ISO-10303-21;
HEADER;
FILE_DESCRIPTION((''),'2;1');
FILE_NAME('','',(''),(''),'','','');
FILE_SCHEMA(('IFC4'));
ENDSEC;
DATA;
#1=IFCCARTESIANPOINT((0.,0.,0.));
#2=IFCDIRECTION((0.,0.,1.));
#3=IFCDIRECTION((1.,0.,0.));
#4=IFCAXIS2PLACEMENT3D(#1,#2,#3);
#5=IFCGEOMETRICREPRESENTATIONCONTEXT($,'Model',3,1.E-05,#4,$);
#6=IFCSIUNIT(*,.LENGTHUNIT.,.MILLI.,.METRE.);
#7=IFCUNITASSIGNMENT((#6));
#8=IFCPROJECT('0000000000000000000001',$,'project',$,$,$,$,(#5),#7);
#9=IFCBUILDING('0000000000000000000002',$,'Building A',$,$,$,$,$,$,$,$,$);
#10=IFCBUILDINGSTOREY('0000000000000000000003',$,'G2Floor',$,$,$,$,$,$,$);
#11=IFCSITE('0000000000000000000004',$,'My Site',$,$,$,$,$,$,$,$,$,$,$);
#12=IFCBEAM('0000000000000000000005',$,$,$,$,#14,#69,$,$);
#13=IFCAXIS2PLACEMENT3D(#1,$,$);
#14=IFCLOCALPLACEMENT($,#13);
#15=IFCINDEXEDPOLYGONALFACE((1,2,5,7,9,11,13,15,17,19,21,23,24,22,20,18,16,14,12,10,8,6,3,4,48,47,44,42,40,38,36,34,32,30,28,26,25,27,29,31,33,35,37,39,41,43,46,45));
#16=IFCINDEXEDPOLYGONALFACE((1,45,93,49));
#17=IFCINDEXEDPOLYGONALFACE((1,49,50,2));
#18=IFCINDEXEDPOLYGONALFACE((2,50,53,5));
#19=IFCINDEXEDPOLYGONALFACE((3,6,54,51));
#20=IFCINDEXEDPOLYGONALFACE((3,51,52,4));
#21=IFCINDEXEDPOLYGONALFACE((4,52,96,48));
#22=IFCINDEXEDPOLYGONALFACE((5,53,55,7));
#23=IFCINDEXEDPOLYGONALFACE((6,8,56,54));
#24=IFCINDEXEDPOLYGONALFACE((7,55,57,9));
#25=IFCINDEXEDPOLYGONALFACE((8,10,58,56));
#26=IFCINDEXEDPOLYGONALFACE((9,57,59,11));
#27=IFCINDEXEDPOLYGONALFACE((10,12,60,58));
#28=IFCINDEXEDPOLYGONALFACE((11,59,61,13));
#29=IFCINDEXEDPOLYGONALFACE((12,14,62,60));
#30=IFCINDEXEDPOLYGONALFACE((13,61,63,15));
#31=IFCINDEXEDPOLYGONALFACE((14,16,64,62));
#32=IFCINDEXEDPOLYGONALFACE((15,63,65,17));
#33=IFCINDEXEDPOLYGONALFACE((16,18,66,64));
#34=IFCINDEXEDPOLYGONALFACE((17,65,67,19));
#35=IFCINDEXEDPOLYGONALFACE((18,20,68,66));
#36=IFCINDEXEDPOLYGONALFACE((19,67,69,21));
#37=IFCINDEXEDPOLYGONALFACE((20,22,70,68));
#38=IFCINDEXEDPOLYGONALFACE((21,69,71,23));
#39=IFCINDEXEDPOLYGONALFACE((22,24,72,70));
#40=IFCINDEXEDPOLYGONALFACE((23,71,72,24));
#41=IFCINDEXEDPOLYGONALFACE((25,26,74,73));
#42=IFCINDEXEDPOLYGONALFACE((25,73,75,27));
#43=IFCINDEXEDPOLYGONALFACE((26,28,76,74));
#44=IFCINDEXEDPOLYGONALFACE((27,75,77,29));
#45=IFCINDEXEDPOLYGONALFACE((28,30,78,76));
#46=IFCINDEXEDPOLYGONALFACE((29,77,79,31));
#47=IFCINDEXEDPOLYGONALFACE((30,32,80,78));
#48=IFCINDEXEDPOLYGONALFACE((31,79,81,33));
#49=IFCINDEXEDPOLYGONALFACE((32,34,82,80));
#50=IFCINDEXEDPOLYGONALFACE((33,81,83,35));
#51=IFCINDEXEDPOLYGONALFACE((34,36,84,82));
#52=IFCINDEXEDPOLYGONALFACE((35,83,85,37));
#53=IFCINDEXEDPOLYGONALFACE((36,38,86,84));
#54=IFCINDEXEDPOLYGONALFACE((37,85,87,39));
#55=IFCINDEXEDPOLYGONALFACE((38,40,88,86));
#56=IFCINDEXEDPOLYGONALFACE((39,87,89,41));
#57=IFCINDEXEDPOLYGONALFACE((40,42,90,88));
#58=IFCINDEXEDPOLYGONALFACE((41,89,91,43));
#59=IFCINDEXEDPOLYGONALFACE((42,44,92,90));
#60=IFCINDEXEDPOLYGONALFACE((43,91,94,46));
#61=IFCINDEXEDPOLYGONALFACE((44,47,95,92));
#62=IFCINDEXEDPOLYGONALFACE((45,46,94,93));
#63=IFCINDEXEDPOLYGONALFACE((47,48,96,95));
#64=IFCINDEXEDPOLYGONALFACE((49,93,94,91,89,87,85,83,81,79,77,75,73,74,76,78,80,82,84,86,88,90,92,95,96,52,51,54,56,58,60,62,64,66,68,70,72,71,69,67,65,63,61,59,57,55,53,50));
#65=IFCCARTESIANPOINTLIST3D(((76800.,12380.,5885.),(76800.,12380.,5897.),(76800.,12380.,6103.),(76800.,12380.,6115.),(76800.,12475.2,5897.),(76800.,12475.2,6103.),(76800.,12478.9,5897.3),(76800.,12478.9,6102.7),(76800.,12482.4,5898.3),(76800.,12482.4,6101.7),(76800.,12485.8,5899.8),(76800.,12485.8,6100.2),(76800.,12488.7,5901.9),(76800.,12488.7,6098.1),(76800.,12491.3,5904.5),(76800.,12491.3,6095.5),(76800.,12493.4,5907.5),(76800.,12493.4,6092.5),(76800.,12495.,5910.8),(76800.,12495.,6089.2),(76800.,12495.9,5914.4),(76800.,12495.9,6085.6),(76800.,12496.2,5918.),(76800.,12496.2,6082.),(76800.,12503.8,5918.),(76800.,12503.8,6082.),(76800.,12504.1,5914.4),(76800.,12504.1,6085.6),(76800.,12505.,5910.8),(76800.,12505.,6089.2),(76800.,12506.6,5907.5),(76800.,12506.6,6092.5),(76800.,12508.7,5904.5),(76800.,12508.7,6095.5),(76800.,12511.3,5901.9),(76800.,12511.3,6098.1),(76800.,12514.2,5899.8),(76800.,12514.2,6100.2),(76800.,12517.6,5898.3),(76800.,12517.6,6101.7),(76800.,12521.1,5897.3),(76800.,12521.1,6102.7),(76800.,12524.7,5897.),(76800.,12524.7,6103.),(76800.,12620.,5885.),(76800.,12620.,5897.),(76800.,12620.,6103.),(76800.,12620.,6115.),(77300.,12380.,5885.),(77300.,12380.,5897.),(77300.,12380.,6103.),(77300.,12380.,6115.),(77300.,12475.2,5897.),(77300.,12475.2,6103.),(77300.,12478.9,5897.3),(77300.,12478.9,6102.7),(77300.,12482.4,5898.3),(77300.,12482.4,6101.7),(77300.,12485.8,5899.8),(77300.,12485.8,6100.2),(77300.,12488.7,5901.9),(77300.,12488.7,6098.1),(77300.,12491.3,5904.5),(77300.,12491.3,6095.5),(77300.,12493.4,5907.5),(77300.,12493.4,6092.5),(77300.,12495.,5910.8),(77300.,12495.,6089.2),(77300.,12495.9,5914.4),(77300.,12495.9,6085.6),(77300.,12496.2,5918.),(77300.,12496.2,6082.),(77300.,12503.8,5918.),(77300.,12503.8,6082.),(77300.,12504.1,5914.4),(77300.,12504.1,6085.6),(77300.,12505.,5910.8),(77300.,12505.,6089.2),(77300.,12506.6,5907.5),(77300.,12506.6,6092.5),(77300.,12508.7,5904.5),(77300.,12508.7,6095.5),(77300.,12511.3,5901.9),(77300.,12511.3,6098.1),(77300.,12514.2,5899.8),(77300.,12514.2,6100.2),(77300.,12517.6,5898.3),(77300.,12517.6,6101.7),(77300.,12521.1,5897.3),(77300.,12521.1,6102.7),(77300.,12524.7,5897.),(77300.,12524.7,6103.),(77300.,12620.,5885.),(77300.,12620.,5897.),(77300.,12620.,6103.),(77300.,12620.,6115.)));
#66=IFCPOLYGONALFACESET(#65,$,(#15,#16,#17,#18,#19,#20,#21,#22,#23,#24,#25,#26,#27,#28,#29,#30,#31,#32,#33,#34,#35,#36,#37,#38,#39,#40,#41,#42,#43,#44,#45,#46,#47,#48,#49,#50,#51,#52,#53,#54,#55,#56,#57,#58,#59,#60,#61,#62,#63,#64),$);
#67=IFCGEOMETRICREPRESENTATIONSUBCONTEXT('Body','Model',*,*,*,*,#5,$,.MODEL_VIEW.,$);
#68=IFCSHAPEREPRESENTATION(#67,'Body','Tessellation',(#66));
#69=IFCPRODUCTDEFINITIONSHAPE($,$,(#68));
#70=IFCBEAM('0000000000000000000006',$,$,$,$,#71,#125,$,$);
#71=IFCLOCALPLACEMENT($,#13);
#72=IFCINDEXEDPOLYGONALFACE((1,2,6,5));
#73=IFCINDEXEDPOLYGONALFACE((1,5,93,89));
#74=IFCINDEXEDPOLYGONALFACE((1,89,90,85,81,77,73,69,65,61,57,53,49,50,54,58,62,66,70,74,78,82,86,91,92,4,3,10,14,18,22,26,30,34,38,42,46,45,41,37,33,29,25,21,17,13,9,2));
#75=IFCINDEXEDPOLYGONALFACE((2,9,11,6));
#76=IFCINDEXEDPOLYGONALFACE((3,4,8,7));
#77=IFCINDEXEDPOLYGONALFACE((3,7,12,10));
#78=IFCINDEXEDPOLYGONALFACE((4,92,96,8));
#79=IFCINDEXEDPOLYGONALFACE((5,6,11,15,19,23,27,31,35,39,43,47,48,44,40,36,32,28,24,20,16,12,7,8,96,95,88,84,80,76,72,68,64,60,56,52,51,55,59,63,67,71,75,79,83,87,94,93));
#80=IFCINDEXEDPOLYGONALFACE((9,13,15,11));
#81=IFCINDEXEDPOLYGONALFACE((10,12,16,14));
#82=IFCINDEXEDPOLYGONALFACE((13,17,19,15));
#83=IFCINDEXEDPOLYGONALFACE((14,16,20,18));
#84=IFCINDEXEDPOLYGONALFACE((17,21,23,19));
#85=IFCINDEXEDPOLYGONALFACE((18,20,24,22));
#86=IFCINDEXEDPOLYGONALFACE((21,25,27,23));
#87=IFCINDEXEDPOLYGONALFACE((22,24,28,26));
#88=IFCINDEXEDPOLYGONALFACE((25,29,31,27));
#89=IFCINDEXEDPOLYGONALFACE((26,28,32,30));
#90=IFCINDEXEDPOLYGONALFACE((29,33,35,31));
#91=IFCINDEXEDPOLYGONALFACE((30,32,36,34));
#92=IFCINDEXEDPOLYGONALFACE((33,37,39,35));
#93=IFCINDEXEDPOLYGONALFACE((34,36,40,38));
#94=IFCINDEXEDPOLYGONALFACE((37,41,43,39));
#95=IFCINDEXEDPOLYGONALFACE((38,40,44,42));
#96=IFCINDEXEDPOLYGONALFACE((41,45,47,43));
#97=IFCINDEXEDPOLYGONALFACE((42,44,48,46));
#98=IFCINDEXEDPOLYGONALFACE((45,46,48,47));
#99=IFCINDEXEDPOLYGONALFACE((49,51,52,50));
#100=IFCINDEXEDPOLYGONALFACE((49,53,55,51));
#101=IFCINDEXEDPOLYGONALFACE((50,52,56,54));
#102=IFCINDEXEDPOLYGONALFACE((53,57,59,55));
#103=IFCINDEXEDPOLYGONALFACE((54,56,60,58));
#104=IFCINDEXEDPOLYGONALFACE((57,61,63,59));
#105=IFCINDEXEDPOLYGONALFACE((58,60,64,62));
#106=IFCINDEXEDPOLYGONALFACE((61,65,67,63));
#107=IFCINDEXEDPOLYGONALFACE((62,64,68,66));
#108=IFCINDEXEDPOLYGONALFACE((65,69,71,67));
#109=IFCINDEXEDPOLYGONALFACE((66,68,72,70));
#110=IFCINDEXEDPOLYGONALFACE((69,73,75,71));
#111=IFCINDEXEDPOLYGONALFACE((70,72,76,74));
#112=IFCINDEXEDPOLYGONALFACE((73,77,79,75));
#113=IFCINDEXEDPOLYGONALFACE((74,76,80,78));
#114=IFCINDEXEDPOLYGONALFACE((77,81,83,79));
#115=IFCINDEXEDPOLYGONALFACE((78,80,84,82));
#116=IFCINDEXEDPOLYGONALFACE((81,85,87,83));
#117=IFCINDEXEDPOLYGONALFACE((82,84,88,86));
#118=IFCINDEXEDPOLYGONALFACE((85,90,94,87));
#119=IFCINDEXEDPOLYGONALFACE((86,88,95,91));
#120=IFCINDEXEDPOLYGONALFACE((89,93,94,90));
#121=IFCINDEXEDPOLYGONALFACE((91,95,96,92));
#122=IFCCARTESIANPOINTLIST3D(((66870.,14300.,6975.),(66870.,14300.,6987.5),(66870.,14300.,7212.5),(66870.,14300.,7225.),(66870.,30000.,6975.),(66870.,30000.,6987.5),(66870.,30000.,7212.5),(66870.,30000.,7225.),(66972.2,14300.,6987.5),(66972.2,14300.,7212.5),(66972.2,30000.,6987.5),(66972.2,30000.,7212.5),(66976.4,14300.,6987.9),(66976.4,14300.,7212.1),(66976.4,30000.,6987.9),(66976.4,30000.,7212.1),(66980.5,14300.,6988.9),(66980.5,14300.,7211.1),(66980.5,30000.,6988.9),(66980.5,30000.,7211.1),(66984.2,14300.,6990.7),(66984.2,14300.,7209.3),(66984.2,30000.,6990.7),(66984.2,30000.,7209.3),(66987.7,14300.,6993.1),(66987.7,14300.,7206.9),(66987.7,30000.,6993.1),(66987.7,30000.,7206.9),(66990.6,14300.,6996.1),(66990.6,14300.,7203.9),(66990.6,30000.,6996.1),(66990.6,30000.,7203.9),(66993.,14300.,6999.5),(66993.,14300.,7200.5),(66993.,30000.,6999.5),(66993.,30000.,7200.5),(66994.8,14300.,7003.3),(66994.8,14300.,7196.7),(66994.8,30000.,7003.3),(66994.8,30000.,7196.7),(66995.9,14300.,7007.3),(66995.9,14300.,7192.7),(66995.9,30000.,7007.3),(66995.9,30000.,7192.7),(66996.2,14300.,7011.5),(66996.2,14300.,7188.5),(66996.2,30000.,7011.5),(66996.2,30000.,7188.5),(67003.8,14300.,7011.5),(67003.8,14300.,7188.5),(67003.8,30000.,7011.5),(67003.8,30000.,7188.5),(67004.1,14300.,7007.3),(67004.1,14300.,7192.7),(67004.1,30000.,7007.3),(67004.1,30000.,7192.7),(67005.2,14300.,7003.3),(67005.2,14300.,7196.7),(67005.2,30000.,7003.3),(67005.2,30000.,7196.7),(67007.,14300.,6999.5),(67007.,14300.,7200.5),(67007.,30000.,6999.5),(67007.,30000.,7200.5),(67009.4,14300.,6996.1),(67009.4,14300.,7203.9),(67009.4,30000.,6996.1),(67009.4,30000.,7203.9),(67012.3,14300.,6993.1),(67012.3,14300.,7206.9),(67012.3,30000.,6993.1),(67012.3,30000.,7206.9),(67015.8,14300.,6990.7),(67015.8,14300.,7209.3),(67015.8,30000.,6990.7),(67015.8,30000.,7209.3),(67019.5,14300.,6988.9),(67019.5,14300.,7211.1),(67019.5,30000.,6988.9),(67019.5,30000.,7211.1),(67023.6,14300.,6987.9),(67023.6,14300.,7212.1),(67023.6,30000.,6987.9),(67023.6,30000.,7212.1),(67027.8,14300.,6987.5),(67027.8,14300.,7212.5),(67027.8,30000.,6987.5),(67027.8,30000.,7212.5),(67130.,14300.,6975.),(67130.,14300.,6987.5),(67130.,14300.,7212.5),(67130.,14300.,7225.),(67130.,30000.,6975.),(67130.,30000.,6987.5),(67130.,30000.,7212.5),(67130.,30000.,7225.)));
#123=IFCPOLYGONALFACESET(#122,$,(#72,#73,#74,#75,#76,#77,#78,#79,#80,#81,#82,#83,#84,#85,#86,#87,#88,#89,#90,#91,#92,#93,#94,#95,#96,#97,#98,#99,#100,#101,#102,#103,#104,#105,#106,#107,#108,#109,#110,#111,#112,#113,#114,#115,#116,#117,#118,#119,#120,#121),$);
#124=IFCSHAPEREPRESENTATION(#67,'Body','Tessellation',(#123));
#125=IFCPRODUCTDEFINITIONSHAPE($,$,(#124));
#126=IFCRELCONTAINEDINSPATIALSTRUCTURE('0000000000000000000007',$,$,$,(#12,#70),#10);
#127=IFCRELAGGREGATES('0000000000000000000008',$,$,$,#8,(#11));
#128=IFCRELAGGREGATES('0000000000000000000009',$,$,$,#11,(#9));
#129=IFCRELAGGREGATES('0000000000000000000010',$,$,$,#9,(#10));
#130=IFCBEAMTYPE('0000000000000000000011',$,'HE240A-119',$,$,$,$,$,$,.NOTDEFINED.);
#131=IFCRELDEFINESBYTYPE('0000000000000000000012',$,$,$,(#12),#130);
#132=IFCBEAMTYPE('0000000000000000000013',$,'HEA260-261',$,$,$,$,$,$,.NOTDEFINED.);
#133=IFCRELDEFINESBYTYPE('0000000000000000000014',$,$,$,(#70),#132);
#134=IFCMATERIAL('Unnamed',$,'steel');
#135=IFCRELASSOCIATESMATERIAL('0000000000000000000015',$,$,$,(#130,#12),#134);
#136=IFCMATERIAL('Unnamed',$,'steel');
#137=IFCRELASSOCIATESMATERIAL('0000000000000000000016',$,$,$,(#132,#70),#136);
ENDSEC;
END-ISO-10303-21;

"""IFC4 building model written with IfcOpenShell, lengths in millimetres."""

from ifc_helpers import new_model, si_unit, frame, origin_with_axes, place, context, subcontext, project, spatial, polyline, outline, extrude, material, material_profile, profile_set, profile_usage, type_object, element, save


model = new_model("IFC4")

# Units and contexts
model_context = context("Model", 3, precision=1e-05, world=origin_with_axes())
body_context = subcontext(model_context, "Body", "Model", "MODEL_VIEW")
ifc_project = project(units=[si_unit("LENGTHUNIT", "METRE", prefix="MILLI")], contexts=[model_context])

# Site, building, storey
site = spatial("IfcSite", under=ifc_project, Name="My Site")
building = spatial("IfcBuilding", under=site, Name="Building A")
storey = spatial("IfcBuildingStorey", under=building, Name="G2Floor")

# Beams
ifc_material_1 = material(Name="Unnamed", Category="steel")
ifc_material_profile_1 = material_profile(ifc_material_1, outline(polyline([(120.0, -115.0), (120.0, -103.0), (120.0, -103.0), (24.8, -103.0), (24.8, -103.0), (21.1, -102.7), (21.1, -102.7), (17.6, -101.7), (17.6, -101.7), (14.2, -100.2), (14.2, -100.2), (11.3, -98.1), (11.3, -98.1), (8.7, -95.5), (8.7, -95.5), (6.6, -92.5), (6.6, -92.5), (5.0, -89.2), (5.0, -89.2), (4.1, -85.6), (4.1, -85.6), (3.8, -82.0), (3.8, -82.0), (3.8, 82.0), (3.8, 82.0), (4.1, 85.6), (4.1, 85.6), (5.0, 89.2), (5.0, 89.2), (6.6, 92.5), (6.6, 92.5), (8.7, 95.5), (8.7, 95.5), (11.3, 98.1), (11.3, 98.1), (14.2, 100.2), (14.2, 100.2), (17.6, 101.7), (17.6, 101.7), (21.1, 102.7), (21.1, 102.7), (24.8, 103.0), (24.8, 103.0), (120.0, 103.0), (120.0, 103.0), (120.0, 115.0), (120.0, 115.0), (-120.0, 115.0), (-120.0, 115.0), (-120.0, 103.0), (-120.0, 103.0), (-24.8, 103.0), (-24.8, 103.0), (-21.1, 102.7), (-21.1, 102.7), (-17.6, 101.7), (-17.6, 101.7), (-14.2, 100.2), (-14.2, 100.2), (-11.3, 98.1), (-11.3, 98.1), (-8.7, 95.5), (-8.7, 95.5), (-6.6, 92.5), (-6.6, 92.5), (-5.0, 89.2), (-5.0, 89.2), (-4.1, 85.6), (-4.1, 85.6), (-3.8, 82.0), (-3.8, 82.0), (-3.8, -82.0), (-3.8, -82.0), (-4.1, -85.6), (-4.1, -85.6), (-5.0, -89.2), (-5.0, -89.2), (-6.6, -92.5), (-6.6, -92.5), (-8.7, -95.5), (-8.7, -95.5), (-11.3, -98.1), (-11.3, -98.1), (-14.2, -100.2), (-14.2, -100.2), (-17.6, -101.7), (-17.6, -101.7), (-21.1, -102.7), (-21.1, -102.7), (-24.8, -103.0), (-24.8, -103.0), (-120.0, -103.0), (-120.0, -103.0), (-120.0, -115.0), (-120.0, -115.0), (120.0, -115.0)])))
ifc_profile_set_1 = profile_set([ifc_material_profile_1], Name="HE240A-119")
ifc_profile_usage_1 = profile_usage(ifc_profile_set_1)
beam_type_1 = type_object("IfcBeamType", Name="HE240A-119", PredefinedType="NOTDEFINED", material=ifc_profile_set_1)
beam_1_placement = place(None, frame((76800.0, 12500.0, 6000.0), z_axis=(1.0, 0.0, 0.0), x_axis=(0.0, -1.0, 0.0)))
element("IfcBeam", 1, at=beam_1_placement, inside=storey, type_object=beam_type_1, material=ifc_profile_usage_1, context=body_context, shape_type="SweptSolid", body=[
    extrude(outline(polyline([(120.0, -115.0), (120.0, -103.0), (120.0, -103.0), (24.8, -103.0), (24.8, -103.0), (21.1, -102.7), (21.1, -102.7), (17.6, -101.7), (17.6, -101.7), (14.2, -100.2), (14.2, -100.2), (11.3, -98.1), (11.3, -98.1), (8.7, -95.5), (8.7, -95.5), (6.6, -92.5), (6.6, -92.5), (5.0, -89.2), (5.0, -89.2), (4.1, -85.6), (4.1, -85.6), (3.8, -82.0), (3.8, -82.0), (3.8, 82.0), (3.8, 82.0), (4.1, 85.6), (4.1, 85.6), (5.0, 89.2), (5.0, 89.2), (6.6, 92.5), (6.6, 92.5), (8.7, 95.5), (8.7, 95.5), (11.3, 98.1), (11.3, 98.1), (14.2, 100.2), (14.2, 100.2), (17.6, 101.7), (17.6, 101.7), (21.1, 102.7), (21.1, 102.7), (24.8, 103.0), (24.8, 103.0), (120.0, 103.0), (120.0, 103.0), (120.0, 115.0), (120.0, 115.0), (-120.0, 115.0), (-120.0, 115.0), (-120.0, 103.0), (-120.0, 103.0), (-24.8, 103.0), (-24.8, 103.0), (-21.1, 102.7), (-21.1, 102.7), (-17.6, 101.7), (-17.6, 101.7), (-14.2, 100.2), (-14.2, 100.2), (-11.3, 98.1), (-11.3, 98.1), (-8.7, 95.5), (-8.7, 95.5), (-6.6, 92.5), (-6.6, 92.5), (-5.0, 89.2), (-5.0, 89.2), (-4.1, 85.6), (-4.1, 85.6), (-3.8, 82.0), (-3.8, 82.0), (-3.8, -82.0), (-3.8, -82.0), (-4.1, -85.6), (-4.1, -85.6), (-5.0, -89.2), (-5.0, -89.2), (-6.6, -92.5), (-6.6, -92.5), (-8.7, -95.5), (-8.7, -95.5), (-11.3, -98.1), (-11.3, -98.1), (-14.2, -100.2), (-14.2, -100.2), (-17.6, -101.7), (-17.6, -101.7), (-21.1, -102.7), (-21.1, -102.7), (-24.8, -103.0), (-24.8, -103.0), (-120.0, -103.0), (-120.0, -103.0), (-120.0, -115.0), (-120.0, -115.0), (120.0, -115.0)])), origin_with_axes(), (0.0, 0.0, 1.0), 500.0),
])
ifc_material_2 = material(Name="Unnamed", Category="steel")
ifc_material_profile_2 = material_profile(ifc_material_2, outline(polyline([(130.0, -125.0), (130.0, -112.5), (130.0, -112.5), (27.8, -112.5), (27.8, -112.5), (23.6, -112.1), (23.6, -112.1), (19.5, -111.1), (19.5, -111.1), (15.8, -109.3), (15.8, -109.3), (12.3, -106.9), (12.3, -106.9), (9.4, -103.9), (9.4, -103.9), (7.0, -100.5), (7.0, -100.5), (5.2, -96.7), (5.2, -96.7), (4.1, -92.7), (4.1, -92.7), (3.8, -88.5), (3.8, -88.5), (3.8, 88.5), (3.8, 88.5), (4.1, 92.7), (4.1, 92.7), (5.2, 96.7), (5.2, 96.7), (7.0, 100.5), (7.0, 100.5), (9.4, 103.9), (9.4, 103.9), (12.3, 106.9), (12.3, 106.9), (15.8, 109.3), (15.8, 109.3), (19.5, 111.1), (19.5, 111.1), (23.6, 112.1), (23.6, 112.1), (27.8, 112.5), (27.8, 112.5), (130.0, 112.5), (130.0, 112.5), (130.0, 125.0), (130.0, 125.0), (-130.0, 125.0), (-130.0, 125.0), (-130.0, 112.5), (-130.0, 112.5), (-27.8, 112.5), (-27.8, 112.5), (-23.6, 112.1), (-23.6, 112.1), (-19.5, 111.1), (-19.5, 111.1), (-15.8, 109.3), (-15.8, 109.3), (-12.3, 106.9), (-12.3, 106.9), (-9.4, 103.9), (-9.4, 103.9), (-7.0, 100.5), (-7.0, 100.5), (-5.2, 96.7), (-5.2, 96.7), (-4.1, 92.7), (-4.1, 92.7), (-3.8, 88.5), (-3.8, 88.5), (-3.8, -88.5), (-3.8, -88.5), (-4.1, -92.7), (-4.1, -92.7), (-5.2, -96.7), (-5.2, -96.7), (-7.0, -100.5), (-7.0, -100.5), (-9.4, -103.9), (-9.4, -103.9), (-12.3, -106.9), (-12.3, -106.9), (-15.8, -109.3), (-15.8, -109.3), (-19.5, -111.1), (-19.5, -111.1), (-23.6, -112.1), (-23.6, -112.1), (-27.8, -112.5), (-27.8, -112.5), (-130.0, -112.5), (-130.0, -112.5), (-130.0, -125.0), (-130.0, -125.0), (130.0, -125.0)])))
ifc_profile_set_2 = profile_set([ifc_material_profile_2], Name="HEA260-261")
ifc_profile_usage_2 = profile_usage(ifc_profile_set_2)
beam_type_2 = type_object("IfcBeamType", Name="HEA260-261", PredefinedType="NOTDEFINED", material=ifc_profile_set_2)
beam_2_placement = place(None, frame((67000.0, 14300.0, 7100.0), z_axis=(0.0, 1.0, 0.0), x_axis=(1.0, 0.0, 0.0)))
element("IfcBeam", 2, at=beam_2_placement, inside=storey, type_object=beam_type_2, material=ifc_profile_usage_2, context=body_context, shape_type="SweptSolid", body=[
    extrude(outline(polyline([(130.0, -125.0), (130.0, -112.5), (130.0, -112.5), (27.8, -112.5), (27.8, -112.5), (23.6, -112.1), (23.6, -112.1), (19.5, -111.1), (19.5, -111.1), (15.8, -109.3), (15.8, -109.3), (12.3, -106.9), (12.3, -106.9), (9.4, -103.9), (9.4, -103.9), (7.0, -100.5), (7.0, -100.5), (5.2, -96.7), (5.2, -96.7), (4.1, -92.7), (4.1, -92.7), (3.8, -88.5), (3.8, -88.5), (3.8, 88.5), (3.8, 88.5), (4.1, 92.7), (4.1, 92.7), (5.2, 96.7), (5.2, 96.7), (7.0, 100.5), (7.0, 100.5), (9.4, 103.9), (9.4, 103.9), (12.3, 106.9), (12.3, 106.9), (15.8, 109.3), (15.8, 109.3), (19.5, 111.1), (19.5, 111.1), (23.6, 112.1), (23.6, 112.1), (27.8, 112.5), (27.8, 112.5), (130.0, 112.5), (130.0, 112.5), (130.0, 125.0), (130.0, 125.0), (-130.0, 125.0), (-130.0, 125.0), (-130.0, 112.5), (-130.0, 112.5), (-27.8, 112.5), (-27.8, 112.5), (-23.6, 112.1), (-23.6, 112.1), (-19.5, 111.1), (-19.5, 111.1), (-15.8, 109.3), (-15.8, 109.3), (-12.3, 106.9), (-12.3, 106.9), (-9.4, 103.9), (-9.4, 103.9), (-7.0, 100.5), (-7.0, 100.5), (-5.2, 96.7), (-5.2, 96.7), (-4.1, 92.7), (-4.1, 92.7), (-3.8, 88.5), (-3.8, 88.5), (-3.8, -88.5), (-3.8, -88.5), (-4.1, -92.7), (-4.1, -92.7), (-5.2, -96.7), (-5.2, -96.7), (-7.0, -100.5), (-7.0, -100.5), (-9.4, -103.9), (-9.4, -103.9), (-12.3, -106.9), (-12.3, -106.9), (-15.8, -109.3), (-15.8, -109.3), (-19.5, -111.1), (-19.5, -111.1), (-23.6, -112.1), (-23.6, -112.1), (-27.8, -112.5), (-27.8, -112.5), (-130.0, -112.5), (-130.0, -112.5), (-130.0, -125.0), (-130.0, -125.0), (130.0, -125.0)])), origin_with_axes(), (0.0, 0.0, 1.0), 15700.0),
])

save(model, "model.ifc")
